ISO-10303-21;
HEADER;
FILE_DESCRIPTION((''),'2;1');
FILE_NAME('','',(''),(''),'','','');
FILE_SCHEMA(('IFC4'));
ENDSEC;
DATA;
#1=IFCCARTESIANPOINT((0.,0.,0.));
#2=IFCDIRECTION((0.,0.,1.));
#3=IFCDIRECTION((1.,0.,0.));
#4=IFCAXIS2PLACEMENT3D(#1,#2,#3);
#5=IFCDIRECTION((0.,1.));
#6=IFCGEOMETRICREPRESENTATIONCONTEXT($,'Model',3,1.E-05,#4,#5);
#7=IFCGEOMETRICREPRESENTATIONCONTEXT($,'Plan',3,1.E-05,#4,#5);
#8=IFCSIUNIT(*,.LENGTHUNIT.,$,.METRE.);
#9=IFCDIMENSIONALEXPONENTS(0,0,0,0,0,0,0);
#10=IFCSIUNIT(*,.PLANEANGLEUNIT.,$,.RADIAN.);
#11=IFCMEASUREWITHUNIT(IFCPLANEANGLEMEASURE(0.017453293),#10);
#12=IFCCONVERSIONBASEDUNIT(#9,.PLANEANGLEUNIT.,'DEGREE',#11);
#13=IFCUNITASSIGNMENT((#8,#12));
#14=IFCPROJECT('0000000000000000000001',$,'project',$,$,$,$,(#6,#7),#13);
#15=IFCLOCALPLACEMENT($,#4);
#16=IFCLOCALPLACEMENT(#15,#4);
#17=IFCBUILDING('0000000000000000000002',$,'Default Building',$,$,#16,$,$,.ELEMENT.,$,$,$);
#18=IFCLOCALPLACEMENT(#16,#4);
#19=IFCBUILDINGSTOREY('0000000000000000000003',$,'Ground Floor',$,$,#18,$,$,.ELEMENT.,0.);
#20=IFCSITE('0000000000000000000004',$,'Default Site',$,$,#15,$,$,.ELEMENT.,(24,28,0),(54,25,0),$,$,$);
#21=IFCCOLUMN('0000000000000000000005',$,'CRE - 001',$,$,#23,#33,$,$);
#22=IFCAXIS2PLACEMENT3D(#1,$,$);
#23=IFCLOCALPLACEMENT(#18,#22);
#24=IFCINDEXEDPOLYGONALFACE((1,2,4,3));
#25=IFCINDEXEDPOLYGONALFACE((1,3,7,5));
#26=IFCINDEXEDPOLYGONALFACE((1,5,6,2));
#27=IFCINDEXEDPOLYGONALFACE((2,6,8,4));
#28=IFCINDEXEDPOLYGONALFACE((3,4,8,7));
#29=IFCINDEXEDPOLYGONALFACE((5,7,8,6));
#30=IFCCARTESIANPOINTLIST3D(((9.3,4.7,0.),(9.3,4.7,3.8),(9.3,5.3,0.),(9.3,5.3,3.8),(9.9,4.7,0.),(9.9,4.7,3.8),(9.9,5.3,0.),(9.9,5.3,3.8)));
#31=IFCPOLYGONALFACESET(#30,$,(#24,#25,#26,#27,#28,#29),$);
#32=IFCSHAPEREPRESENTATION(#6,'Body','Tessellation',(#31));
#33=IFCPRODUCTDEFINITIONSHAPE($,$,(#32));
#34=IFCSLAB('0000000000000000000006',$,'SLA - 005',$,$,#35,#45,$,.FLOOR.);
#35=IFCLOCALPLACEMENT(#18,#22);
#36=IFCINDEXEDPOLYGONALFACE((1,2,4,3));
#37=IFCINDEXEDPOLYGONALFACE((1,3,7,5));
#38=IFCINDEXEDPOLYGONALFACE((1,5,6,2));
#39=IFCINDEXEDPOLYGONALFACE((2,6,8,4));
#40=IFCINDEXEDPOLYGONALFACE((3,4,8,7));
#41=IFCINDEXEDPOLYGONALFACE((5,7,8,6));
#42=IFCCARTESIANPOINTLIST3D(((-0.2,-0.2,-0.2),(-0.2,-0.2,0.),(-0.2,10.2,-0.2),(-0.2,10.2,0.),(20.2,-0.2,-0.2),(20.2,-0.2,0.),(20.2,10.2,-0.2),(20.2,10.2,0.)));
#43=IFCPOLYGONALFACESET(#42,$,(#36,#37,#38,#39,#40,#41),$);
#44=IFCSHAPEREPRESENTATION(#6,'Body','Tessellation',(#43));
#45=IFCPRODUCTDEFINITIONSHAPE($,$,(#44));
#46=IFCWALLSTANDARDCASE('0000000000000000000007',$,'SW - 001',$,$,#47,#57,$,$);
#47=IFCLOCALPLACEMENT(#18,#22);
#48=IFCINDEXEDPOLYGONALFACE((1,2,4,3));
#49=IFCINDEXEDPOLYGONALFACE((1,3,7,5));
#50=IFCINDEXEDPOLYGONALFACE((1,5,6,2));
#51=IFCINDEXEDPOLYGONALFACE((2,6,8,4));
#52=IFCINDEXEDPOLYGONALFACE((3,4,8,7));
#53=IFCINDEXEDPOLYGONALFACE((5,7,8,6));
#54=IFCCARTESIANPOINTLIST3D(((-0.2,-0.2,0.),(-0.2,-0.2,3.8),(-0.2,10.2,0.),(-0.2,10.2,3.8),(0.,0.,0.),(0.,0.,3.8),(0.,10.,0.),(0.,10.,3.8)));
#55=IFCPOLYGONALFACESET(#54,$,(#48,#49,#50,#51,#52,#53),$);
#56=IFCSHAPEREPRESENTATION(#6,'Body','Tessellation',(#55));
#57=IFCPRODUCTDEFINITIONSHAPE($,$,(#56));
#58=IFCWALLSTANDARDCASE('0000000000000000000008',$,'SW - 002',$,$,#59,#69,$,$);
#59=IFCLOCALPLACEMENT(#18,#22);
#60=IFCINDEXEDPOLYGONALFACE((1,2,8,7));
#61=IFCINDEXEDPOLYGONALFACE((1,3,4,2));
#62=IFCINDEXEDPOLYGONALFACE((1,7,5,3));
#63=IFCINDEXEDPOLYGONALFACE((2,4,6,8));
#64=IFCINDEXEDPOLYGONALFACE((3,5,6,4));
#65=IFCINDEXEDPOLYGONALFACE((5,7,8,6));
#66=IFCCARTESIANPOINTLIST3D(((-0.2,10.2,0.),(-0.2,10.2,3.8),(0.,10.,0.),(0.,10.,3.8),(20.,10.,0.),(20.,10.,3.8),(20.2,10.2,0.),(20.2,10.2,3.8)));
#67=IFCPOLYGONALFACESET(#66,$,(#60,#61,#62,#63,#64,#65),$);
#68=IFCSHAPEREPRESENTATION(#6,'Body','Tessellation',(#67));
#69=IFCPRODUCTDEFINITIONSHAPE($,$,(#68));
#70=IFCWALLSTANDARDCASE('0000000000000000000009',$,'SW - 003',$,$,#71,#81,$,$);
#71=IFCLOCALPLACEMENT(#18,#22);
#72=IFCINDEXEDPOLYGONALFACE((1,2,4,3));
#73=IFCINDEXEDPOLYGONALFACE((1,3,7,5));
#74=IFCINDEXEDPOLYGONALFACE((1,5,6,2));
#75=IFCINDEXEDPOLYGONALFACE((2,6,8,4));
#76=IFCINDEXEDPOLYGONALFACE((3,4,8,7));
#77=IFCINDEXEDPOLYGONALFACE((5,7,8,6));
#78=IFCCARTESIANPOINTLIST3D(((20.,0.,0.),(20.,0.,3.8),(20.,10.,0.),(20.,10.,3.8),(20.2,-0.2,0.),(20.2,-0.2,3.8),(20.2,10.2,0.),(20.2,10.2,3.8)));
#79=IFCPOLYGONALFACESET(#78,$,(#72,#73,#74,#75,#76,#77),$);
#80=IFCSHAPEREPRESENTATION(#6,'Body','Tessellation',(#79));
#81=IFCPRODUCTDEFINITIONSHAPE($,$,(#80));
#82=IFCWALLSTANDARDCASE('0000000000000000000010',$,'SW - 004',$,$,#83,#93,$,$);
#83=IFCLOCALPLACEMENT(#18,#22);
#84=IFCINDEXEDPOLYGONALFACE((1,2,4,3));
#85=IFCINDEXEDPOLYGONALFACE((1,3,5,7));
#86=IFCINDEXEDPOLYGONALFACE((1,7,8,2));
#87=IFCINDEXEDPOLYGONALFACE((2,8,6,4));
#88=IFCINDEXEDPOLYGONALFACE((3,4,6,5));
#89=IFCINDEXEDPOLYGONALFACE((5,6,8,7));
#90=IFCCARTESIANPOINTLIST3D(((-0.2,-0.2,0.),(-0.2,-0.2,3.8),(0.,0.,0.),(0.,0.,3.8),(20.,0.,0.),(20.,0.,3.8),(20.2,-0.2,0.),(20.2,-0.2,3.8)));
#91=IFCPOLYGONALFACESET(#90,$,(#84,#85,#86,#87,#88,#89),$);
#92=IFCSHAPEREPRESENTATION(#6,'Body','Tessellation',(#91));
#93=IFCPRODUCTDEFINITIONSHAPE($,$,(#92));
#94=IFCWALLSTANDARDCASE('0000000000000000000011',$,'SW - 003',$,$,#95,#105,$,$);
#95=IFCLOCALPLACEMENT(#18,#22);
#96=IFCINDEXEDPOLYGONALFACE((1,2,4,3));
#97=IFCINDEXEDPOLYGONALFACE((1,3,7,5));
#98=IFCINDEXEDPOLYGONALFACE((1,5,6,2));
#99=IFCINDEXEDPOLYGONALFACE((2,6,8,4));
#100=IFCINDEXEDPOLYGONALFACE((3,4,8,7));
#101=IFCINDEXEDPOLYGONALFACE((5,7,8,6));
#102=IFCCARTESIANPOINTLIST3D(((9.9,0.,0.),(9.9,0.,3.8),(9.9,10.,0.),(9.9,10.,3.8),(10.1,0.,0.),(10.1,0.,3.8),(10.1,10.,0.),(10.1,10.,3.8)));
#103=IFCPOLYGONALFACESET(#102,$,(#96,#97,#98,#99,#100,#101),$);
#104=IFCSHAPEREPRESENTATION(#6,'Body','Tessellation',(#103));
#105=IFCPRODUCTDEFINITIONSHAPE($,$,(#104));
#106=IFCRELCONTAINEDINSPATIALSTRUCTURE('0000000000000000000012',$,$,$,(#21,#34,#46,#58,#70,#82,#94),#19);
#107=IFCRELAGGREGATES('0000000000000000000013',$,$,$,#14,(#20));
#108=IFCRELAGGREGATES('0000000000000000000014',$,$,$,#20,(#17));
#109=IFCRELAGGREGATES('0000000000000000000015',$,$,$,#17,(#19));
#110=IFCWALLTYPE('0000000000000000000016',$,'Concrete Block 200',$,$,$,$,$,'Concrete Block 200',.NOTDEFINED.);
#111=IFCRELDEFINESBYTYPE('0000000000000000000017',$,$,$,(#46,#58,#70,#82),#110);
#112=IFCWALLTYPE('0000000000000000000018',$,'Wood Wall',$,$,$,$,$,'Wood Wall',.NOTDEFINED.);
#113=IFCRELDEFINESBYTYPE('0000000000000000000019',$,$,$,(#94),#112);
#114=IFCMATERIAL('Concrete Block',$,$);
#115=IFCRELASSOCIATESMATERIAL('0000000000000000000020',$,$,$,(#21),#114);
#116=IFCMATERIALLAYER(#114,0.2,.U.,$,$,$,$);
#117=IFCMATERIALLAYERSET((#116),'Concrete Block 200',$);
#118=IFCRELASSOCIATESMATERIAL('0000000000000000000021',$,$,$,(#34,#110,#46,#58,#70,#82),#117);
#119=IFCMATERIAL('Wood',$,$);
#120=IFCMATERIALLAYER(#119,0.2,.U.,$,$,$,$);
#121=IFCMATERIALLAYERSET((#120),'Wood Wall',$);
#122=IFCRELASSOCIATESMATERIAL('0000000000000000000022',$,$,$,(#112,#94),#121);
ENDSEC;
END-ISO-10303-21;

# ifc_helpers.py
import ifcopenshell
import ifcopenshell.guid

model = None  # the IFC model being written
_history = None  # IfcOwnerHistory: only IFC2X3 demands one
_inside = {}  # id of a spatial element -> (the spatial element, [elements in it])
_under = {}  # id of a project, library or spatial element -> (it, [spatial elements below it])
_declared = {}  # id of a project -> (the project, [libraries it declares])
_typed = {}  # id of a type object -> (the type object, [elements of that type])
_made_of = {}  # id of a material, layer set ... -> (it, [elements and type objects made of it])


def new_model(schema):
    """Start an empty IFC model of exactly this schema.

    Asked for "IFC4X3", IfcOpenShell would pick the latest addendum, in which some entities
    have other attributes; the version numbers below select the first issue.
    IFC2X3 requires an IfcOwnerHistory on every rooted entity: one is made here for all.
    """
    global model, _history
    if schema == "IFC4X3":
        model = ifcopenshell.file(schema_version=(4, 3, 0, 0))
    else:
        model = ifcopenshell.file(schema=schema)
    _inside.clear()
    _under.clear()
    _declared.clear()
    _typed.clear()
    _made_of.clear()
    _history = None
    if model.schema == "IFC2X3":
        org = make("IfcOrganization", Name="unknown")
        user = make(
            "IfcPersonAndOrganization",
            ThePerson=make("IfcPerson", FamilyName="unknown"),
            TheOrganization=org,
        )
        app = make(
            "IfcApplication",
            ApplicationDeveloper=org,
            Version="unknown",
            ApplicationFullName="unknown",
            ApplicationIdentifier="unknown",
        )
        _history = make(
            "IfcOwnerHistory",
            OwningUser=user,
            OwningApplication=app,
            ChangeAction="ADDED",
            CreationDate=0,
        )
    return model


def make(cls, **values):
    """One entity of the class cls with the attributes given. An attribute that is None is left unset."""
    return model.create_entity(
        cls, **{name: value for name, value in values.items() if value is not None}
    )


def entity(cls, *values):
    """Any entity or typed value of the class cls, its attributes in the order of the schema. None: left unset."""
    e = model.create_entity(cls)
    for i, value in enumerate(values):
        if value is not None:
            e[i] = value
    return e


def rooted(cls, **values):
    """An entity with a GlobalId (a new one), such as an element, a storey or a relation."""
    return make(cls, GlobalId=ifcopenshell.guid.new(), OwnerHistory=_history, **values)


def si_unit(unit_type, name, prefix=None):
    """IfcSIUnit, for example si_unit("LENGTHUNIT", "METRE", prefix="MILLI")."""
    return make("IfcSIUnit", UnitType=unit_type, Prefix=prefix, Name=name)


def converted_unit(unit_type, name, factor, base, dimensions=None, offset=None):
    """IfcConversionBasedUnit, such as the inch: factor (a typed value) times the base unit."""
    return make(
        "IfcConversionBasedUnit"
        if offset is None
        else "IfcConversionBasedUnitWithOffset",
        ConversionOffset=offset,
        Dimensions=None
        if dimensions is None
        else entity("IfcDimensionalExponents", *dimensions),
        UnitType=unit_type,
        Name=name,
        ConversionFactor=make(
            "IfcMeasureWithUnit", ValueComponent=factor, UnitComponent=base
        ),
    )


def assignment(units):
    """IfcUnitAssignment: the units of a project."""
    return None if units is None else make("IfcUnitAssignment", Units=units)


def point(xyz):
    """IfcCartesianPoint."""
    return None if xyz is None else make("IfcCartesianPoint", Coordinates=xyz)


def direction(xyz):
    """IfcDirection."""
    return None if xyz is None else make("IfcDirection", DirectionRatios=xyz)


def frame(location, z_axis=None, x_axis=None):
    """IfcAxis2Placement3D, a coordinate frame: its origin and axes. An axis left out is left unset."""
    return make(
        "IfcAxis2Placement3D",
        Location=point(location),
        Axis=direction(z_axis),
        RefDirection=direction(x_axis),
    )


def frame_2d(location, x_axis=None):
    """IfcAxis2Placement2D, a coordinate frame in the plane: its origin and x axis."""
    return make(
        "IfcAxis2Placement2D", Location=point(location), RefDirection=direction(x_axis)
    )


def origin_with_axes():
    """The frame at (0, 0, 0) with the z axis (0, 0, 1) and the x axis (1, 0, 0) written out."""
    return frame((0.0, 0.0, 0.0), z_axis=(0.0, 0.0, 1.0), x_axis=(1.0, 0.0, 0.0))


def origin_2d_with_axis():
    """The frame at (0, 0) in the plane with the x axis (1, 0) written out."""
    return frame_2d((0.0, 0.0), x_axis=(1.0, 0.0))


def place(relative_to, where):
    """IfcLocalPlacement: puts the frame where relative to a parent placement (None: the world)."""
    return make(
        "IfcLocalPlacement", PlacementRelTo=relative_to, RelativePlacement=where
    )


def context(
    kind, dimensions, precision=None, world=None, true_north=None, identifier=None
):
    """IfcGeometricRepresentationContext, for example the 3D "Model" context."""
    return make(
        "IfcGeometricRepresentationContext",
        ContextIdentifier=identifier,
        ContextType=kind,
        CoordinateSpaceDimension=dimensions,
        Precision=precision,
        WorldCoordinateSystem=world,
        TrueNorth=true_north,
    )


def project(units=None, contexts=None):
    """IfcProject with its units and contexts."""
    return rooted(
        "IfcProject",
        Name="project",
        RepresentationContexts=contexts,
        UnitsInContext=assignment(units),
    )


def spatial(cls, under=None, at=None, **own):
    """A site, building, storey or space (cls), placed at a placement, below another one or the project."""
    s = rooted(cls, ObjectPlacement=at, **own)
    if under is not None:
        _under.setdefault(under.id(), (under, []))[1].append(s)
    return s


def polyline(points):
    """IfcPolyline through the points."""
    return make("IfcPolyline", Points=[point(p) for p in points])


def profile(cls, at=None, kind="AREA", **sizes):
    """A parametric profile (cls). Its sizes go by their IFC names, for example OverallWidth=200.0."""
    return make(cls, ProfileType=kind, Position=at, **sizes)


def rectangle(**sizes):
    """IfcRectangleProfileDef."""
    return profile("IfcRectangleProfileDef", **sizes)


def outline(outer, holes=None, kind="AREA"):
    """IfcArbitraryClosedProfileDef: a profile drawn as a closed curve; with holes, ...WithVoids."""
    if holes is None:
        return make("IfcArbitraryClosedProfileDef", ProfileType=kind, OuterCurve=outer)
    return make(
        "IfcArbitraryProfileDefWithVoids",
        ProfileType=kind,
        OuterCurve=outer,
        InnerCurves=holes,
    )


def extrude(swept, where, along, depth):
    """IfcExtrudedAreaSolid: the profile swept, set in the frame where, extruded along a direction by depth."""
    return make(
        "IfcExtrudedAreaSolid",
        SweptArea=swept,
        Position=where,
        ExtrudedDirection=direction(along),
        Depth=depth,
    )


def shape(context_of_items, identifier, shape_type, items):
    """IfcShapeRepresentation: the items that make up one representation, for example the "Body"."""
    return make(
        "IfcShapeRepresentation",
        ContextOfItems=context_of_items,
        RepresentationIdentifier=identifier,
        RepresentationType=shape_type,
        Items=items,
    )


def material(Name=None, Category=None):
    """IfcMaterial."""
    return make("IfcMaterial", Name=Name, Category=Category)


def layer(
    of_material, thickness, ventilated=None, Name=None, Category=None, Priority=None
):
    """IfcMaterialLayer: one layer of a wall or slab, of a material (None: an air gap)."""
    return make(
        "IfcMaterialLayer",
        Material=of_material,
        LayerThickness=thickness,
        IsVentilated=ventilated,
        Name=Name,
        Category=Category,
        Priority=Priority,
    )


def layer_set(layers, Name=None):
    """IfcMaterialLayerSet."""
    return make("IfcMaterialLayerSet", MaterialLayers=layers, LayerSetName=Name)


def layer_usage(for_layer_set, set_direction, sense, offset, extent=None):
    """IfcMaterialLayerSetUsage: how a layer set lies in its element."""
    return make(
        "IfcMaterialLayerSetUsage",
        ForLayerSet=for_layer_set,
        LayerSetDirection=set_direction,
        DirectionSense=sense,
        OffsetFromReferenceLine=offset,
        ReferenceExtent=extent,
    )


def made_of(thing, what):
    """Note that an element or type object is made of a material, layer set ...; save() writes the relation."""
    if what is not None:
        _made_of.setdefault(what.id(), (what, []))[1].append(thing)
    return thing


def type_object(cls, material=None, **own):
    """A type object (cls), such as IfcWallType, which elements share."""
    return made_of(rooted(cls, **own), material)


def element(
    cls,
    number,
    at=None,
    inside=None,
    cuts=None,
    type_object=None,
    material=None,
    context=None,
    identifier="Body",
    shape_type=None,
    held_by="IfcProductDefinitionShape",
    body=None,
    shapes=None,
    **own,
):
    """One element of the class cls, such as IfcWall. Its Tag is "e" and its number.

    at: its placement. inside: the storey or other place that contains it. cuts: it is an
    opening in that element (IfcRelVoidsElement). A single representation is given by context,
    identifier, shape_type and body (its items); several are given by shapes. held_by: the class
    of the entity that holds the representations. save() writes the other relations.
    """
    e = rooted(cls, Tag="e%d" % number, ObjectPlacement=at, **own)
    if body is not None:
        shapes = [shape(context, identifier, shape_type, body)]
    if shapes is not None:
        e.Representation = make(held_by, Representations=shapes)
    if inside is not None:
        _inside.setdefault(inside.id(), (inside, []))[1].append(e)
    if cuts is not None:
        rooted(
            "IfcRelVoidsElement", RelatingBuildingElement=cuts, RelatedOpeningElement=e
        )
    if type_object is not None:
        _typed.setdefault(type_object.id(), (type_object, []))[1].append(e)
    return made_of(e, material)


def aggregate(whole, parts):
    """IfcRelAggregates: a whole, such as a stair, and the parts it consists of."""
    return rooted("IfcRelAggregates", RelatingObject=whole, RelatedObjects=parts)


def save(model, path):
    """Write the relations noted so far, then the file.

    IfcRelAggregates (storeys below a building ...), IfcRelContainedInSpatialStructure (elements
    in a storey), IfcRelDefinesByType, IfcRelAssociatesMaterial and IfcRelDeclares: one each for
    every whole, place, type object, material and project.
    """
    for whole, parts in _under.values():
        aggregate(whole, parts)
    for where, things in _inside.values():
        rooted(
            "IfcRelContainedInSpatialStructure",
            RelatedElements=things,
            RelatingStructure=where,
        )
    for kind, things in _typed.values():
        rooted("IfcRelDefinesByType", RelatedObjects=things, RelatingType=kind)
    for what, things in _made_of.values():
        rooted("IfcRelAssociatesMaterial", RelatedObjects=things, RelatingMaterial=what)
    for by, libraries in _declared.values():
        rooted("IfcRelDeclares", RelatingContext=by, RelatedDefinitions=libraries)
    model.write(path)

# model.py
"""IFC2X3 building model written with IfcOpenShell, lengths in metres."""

from ifc_helpers import new_model, entity, si_unit, converted_unit, direction, frame, origin_with_axes, origin_2d_with_axis, place, context, project, spatial, polyline, rectangle, outline, extrude, material, layer, layer_set, layer_usage, type_object, element, save


model = new_model("IFC2X3")

# Units and contexts
model_context = context("Model", 3, precision=1e-05, world=origin_with_axes(), true_north=direction((0.0, 1.0)))
plan_context = context("Plan", 3, precision=1e-05, world=origin_with_axes(), true_north=direction((0.0, 1.0)))
ifc_project = project(units=[si_unit("LENGTHUNIT", "METRE"), converted_unit("PLANEANGLEUNIT", "DEGREE", entity("IfcPlaneAngleMeasure", 0.017453293), si_unit("PLANEANGLEUNIT", "RADIAN"), dimensions=[0, 0, 0, 0, 0, 0, 0])], contexts=[model_context, plan_context])

# Site, building, storey
site_placement = place(None, origin_with_axes())
site = spatial("IfcSite", under=ifc_project, at=site_placement, Name="Default Site", CompositionType="ELEMENT", RefLatitude=(24, 28, 0), RefLongitude=(54, 25, 0))
building_placement = place(site_placement, origin_with_axes())
building = spatial("IfcBuilding", under=site, at=building_placement, Name="Default Building", CompositionType="ELEMENT")
storey_placement = place(building_placement, origin_with_axes())
storey = spatial("IfcBuildingStorey", under=building, at=storey_placement, Name="Ground Floor", CompositionType="ELEMENT", Elevation=0.0)

# Column
ifc_material_1 = material(Name="Concrete Block")
column_placement = place(storey_placement, frame((9.6, 5.0, 0.0), z_axis=(0.0, 0.0, 1.0), x_axis=(1.0, 0.0, 0.0)))
element("IfcColumn", 1, at=column_placement, inside=storey, material=ifc_material_1, Name="CRE - 001", context=model_context, shape_type="SweptSolid", body=[
    extrude(rectangle(XDim=0.6, YDim=0.6, at=origin_2d_with_axis()), origin_with_axes(), (0.0, 0.0, 1.0), 3.8),
])

# Slab
ifc_layer_1 = layer(ifc_material_1, 0.2, ventilated="UNKNOWN")
ifc_layer_set_1 = layer_set([ifc_layer_1], Name="Concrete Block 200")
ifc_layer_usage_1 = layer_usage(ifc_layer_set_1, "AXIS3", "NEGATIVE", 0.2)
slab_placement = place(storey_placement, frame((-0.2, 10.2, -0.2), z_axis=(0.0, 0.0, 1.0), x_axis=(1.0, 0.0, 0.0)))
element("IfcSlab", 2, at=slab_placement, inside=storey, material=ifc_layer_usage_1, Name="SLA - 005", PredefinedType="FLOOR", context=model_context, shape_type="SweptSolid", body=[
    extrude(outline(polyline([(0.0, 0.0), (20.4, 0.0), (20.4, -10.4), (0.0, -10.4), (0.0, 0.0)])), origin_with_axes(), (0.0, 0.0, 1.0), 0.2),
])

# Walls
ifc_layer_usage_2 = layer_usage(ifc_layer_set_1, "AXIS2", "POSITIVE", 0.0)
wall_type_1 = type_object("IfcWallType", Name="Concrete Block 200", ElementType="Concrete Block 200", PredefinedType="NOTDEFINED", material=ifc_layer_set_1)
wall_1_placement = place(storey_placement, frame((0.0, 0.0, 0.0), z_axis=(0.0, 0.0, 1.0), x_axis=(0.0, 1.0, 0.0)))
element("IfcWallStandardCase", 3, at=wall_1_placement, inside=storey, type_object=wall_type_1, material=ifc_layer_usage_2, Name="SW - 001", context=model_context, shape_type="SweptSolid", body=[
    extrude(outline(polyline([(0.0, 0.0), (10.0, 0.0), (10.2, 0.2), (-0.2, 0.2), (0.0, 0.0)])), origin_with_axes(), (0.0, 0.0, 1.0), 3.8),
])
ifc_layer_usage_3 = layer_usage(ifc_layer_set_1, "AXIS2", "POSITIVE", 0.0)
wall_2_placement = place(storey_placement, frame((0.0, 10.0, 0.0), z_axis=(0.0, 0.0, 1.0), x_axis=(1.0, 0.0, 0.0)))
element("IfcWallStandardCase", 4, at=wall_2_placement, inside=storey, type_object=wall_type_1, material=ifc_layer_usage_3, Name="SW - 002", context=model_context, shape_type="SweptSolid", body=[
    extrude(outline(polyline([(0.0, 0.0), (20.0, 0.0), (20.2, 0.2), (-0.2, 0.2), (0.0, 0.0)])), origin_with_axes(), (0.0, 0.0, 1.0), 3.8),
])
ifc_layer_usage_4 = layer_usage(ifc_layer_set_1, "AXIS2", "POSITIVE", 0.0)
wall_3_placement = place(storey_placement, frame((20.0, 10.0, 0.0), z_axis=(0.0, 0.0, 1.0), x_axis=(0.0, -1.0, 0.0)))
element("IfcWallStandardCase", 5, at=wall_3_placement, inside=storey, type_object=wall_type_1, material=ifc_layer_usage_4, Name="SW - 003", context=model_context, shape_type="SweptSolid", body=[
    extrude(outline(polyline([(0.0, 0.0), (10.0, 0.0), (10.2, 0.2), (-0.2, 0.2), (0.0, 0.0)])), origin_with_axes(), (0.0, 0.0, 1.0), 3.8),
])
ifc_layer_usage_5 = layer_usage(ifc_layer_set_1, "AXIS2", "POSITIVE", 0.0)
wall_4_placement = place(storey_placement, frame((20.0, 0.0, 0.0), z_axis=(0.0, 0.0, 1.0), x_axis=(-1.0, 0.0, 0.0)))
element("IfcWallStandardCase", 6, at=wall_4_placement, inside=storey, type_object=wall_type_1, material=ifc_layer_usage_5, Name="SW - 004", context=model_context, shape_type="SweptSolid", body=[
    extrude(outline(polyline([(0.0, 0.0), (20.0, 0.0), (20.2, 0.2), (-0.2, 0.2), (0.0, 0.0)])), origin_with_axes(), (0.0, 0.0, 1.0), 3.8),
])
ifc_material_2 = material(Name="Wood")
ifc_layer_2 = layer(ifc_material_2, 0.2, ventilated="UNKNOWN")
ifc_layer_set_2 = layer_set([ifc_layer_2], Name="Wood Wall")
ifc_layer_usage_6 = layer_usage(ifc_layer_set_2, "AXIS2", "NEGATIVE", 0.0)
wall_type_2 = type_object("IfcWallType", Name="Wood Wall", ElementType="Wood Wall", PredefinedType="NOTDEFINED", material=ifc_layer_set_2)
wall_5_placement = place(storey_placement, frame((10.1, 10.0, 0.0), z_axis=(0.0, 0.0, 1.0), x_axis=(0.0, -1.0, 0.0)))
element("IfcWallStandardCase", 7, at=wall_5_placement, inside=storey, type_object=wall_type_2, material=ifc_layer_usage_6, Name="SW - 003", context=model_context, shape_type="SweptSolid", body=[
    extrude(outline(polyline([(0.0, -0.2), (10.0, -0.2), (10.0, 0.0), (0.0, 0.0), (0.0, -0.2)])), origin_with_axes(), (0.0, 0.0, 1.0), 3.8),
])

save(model, "model.ifc")
